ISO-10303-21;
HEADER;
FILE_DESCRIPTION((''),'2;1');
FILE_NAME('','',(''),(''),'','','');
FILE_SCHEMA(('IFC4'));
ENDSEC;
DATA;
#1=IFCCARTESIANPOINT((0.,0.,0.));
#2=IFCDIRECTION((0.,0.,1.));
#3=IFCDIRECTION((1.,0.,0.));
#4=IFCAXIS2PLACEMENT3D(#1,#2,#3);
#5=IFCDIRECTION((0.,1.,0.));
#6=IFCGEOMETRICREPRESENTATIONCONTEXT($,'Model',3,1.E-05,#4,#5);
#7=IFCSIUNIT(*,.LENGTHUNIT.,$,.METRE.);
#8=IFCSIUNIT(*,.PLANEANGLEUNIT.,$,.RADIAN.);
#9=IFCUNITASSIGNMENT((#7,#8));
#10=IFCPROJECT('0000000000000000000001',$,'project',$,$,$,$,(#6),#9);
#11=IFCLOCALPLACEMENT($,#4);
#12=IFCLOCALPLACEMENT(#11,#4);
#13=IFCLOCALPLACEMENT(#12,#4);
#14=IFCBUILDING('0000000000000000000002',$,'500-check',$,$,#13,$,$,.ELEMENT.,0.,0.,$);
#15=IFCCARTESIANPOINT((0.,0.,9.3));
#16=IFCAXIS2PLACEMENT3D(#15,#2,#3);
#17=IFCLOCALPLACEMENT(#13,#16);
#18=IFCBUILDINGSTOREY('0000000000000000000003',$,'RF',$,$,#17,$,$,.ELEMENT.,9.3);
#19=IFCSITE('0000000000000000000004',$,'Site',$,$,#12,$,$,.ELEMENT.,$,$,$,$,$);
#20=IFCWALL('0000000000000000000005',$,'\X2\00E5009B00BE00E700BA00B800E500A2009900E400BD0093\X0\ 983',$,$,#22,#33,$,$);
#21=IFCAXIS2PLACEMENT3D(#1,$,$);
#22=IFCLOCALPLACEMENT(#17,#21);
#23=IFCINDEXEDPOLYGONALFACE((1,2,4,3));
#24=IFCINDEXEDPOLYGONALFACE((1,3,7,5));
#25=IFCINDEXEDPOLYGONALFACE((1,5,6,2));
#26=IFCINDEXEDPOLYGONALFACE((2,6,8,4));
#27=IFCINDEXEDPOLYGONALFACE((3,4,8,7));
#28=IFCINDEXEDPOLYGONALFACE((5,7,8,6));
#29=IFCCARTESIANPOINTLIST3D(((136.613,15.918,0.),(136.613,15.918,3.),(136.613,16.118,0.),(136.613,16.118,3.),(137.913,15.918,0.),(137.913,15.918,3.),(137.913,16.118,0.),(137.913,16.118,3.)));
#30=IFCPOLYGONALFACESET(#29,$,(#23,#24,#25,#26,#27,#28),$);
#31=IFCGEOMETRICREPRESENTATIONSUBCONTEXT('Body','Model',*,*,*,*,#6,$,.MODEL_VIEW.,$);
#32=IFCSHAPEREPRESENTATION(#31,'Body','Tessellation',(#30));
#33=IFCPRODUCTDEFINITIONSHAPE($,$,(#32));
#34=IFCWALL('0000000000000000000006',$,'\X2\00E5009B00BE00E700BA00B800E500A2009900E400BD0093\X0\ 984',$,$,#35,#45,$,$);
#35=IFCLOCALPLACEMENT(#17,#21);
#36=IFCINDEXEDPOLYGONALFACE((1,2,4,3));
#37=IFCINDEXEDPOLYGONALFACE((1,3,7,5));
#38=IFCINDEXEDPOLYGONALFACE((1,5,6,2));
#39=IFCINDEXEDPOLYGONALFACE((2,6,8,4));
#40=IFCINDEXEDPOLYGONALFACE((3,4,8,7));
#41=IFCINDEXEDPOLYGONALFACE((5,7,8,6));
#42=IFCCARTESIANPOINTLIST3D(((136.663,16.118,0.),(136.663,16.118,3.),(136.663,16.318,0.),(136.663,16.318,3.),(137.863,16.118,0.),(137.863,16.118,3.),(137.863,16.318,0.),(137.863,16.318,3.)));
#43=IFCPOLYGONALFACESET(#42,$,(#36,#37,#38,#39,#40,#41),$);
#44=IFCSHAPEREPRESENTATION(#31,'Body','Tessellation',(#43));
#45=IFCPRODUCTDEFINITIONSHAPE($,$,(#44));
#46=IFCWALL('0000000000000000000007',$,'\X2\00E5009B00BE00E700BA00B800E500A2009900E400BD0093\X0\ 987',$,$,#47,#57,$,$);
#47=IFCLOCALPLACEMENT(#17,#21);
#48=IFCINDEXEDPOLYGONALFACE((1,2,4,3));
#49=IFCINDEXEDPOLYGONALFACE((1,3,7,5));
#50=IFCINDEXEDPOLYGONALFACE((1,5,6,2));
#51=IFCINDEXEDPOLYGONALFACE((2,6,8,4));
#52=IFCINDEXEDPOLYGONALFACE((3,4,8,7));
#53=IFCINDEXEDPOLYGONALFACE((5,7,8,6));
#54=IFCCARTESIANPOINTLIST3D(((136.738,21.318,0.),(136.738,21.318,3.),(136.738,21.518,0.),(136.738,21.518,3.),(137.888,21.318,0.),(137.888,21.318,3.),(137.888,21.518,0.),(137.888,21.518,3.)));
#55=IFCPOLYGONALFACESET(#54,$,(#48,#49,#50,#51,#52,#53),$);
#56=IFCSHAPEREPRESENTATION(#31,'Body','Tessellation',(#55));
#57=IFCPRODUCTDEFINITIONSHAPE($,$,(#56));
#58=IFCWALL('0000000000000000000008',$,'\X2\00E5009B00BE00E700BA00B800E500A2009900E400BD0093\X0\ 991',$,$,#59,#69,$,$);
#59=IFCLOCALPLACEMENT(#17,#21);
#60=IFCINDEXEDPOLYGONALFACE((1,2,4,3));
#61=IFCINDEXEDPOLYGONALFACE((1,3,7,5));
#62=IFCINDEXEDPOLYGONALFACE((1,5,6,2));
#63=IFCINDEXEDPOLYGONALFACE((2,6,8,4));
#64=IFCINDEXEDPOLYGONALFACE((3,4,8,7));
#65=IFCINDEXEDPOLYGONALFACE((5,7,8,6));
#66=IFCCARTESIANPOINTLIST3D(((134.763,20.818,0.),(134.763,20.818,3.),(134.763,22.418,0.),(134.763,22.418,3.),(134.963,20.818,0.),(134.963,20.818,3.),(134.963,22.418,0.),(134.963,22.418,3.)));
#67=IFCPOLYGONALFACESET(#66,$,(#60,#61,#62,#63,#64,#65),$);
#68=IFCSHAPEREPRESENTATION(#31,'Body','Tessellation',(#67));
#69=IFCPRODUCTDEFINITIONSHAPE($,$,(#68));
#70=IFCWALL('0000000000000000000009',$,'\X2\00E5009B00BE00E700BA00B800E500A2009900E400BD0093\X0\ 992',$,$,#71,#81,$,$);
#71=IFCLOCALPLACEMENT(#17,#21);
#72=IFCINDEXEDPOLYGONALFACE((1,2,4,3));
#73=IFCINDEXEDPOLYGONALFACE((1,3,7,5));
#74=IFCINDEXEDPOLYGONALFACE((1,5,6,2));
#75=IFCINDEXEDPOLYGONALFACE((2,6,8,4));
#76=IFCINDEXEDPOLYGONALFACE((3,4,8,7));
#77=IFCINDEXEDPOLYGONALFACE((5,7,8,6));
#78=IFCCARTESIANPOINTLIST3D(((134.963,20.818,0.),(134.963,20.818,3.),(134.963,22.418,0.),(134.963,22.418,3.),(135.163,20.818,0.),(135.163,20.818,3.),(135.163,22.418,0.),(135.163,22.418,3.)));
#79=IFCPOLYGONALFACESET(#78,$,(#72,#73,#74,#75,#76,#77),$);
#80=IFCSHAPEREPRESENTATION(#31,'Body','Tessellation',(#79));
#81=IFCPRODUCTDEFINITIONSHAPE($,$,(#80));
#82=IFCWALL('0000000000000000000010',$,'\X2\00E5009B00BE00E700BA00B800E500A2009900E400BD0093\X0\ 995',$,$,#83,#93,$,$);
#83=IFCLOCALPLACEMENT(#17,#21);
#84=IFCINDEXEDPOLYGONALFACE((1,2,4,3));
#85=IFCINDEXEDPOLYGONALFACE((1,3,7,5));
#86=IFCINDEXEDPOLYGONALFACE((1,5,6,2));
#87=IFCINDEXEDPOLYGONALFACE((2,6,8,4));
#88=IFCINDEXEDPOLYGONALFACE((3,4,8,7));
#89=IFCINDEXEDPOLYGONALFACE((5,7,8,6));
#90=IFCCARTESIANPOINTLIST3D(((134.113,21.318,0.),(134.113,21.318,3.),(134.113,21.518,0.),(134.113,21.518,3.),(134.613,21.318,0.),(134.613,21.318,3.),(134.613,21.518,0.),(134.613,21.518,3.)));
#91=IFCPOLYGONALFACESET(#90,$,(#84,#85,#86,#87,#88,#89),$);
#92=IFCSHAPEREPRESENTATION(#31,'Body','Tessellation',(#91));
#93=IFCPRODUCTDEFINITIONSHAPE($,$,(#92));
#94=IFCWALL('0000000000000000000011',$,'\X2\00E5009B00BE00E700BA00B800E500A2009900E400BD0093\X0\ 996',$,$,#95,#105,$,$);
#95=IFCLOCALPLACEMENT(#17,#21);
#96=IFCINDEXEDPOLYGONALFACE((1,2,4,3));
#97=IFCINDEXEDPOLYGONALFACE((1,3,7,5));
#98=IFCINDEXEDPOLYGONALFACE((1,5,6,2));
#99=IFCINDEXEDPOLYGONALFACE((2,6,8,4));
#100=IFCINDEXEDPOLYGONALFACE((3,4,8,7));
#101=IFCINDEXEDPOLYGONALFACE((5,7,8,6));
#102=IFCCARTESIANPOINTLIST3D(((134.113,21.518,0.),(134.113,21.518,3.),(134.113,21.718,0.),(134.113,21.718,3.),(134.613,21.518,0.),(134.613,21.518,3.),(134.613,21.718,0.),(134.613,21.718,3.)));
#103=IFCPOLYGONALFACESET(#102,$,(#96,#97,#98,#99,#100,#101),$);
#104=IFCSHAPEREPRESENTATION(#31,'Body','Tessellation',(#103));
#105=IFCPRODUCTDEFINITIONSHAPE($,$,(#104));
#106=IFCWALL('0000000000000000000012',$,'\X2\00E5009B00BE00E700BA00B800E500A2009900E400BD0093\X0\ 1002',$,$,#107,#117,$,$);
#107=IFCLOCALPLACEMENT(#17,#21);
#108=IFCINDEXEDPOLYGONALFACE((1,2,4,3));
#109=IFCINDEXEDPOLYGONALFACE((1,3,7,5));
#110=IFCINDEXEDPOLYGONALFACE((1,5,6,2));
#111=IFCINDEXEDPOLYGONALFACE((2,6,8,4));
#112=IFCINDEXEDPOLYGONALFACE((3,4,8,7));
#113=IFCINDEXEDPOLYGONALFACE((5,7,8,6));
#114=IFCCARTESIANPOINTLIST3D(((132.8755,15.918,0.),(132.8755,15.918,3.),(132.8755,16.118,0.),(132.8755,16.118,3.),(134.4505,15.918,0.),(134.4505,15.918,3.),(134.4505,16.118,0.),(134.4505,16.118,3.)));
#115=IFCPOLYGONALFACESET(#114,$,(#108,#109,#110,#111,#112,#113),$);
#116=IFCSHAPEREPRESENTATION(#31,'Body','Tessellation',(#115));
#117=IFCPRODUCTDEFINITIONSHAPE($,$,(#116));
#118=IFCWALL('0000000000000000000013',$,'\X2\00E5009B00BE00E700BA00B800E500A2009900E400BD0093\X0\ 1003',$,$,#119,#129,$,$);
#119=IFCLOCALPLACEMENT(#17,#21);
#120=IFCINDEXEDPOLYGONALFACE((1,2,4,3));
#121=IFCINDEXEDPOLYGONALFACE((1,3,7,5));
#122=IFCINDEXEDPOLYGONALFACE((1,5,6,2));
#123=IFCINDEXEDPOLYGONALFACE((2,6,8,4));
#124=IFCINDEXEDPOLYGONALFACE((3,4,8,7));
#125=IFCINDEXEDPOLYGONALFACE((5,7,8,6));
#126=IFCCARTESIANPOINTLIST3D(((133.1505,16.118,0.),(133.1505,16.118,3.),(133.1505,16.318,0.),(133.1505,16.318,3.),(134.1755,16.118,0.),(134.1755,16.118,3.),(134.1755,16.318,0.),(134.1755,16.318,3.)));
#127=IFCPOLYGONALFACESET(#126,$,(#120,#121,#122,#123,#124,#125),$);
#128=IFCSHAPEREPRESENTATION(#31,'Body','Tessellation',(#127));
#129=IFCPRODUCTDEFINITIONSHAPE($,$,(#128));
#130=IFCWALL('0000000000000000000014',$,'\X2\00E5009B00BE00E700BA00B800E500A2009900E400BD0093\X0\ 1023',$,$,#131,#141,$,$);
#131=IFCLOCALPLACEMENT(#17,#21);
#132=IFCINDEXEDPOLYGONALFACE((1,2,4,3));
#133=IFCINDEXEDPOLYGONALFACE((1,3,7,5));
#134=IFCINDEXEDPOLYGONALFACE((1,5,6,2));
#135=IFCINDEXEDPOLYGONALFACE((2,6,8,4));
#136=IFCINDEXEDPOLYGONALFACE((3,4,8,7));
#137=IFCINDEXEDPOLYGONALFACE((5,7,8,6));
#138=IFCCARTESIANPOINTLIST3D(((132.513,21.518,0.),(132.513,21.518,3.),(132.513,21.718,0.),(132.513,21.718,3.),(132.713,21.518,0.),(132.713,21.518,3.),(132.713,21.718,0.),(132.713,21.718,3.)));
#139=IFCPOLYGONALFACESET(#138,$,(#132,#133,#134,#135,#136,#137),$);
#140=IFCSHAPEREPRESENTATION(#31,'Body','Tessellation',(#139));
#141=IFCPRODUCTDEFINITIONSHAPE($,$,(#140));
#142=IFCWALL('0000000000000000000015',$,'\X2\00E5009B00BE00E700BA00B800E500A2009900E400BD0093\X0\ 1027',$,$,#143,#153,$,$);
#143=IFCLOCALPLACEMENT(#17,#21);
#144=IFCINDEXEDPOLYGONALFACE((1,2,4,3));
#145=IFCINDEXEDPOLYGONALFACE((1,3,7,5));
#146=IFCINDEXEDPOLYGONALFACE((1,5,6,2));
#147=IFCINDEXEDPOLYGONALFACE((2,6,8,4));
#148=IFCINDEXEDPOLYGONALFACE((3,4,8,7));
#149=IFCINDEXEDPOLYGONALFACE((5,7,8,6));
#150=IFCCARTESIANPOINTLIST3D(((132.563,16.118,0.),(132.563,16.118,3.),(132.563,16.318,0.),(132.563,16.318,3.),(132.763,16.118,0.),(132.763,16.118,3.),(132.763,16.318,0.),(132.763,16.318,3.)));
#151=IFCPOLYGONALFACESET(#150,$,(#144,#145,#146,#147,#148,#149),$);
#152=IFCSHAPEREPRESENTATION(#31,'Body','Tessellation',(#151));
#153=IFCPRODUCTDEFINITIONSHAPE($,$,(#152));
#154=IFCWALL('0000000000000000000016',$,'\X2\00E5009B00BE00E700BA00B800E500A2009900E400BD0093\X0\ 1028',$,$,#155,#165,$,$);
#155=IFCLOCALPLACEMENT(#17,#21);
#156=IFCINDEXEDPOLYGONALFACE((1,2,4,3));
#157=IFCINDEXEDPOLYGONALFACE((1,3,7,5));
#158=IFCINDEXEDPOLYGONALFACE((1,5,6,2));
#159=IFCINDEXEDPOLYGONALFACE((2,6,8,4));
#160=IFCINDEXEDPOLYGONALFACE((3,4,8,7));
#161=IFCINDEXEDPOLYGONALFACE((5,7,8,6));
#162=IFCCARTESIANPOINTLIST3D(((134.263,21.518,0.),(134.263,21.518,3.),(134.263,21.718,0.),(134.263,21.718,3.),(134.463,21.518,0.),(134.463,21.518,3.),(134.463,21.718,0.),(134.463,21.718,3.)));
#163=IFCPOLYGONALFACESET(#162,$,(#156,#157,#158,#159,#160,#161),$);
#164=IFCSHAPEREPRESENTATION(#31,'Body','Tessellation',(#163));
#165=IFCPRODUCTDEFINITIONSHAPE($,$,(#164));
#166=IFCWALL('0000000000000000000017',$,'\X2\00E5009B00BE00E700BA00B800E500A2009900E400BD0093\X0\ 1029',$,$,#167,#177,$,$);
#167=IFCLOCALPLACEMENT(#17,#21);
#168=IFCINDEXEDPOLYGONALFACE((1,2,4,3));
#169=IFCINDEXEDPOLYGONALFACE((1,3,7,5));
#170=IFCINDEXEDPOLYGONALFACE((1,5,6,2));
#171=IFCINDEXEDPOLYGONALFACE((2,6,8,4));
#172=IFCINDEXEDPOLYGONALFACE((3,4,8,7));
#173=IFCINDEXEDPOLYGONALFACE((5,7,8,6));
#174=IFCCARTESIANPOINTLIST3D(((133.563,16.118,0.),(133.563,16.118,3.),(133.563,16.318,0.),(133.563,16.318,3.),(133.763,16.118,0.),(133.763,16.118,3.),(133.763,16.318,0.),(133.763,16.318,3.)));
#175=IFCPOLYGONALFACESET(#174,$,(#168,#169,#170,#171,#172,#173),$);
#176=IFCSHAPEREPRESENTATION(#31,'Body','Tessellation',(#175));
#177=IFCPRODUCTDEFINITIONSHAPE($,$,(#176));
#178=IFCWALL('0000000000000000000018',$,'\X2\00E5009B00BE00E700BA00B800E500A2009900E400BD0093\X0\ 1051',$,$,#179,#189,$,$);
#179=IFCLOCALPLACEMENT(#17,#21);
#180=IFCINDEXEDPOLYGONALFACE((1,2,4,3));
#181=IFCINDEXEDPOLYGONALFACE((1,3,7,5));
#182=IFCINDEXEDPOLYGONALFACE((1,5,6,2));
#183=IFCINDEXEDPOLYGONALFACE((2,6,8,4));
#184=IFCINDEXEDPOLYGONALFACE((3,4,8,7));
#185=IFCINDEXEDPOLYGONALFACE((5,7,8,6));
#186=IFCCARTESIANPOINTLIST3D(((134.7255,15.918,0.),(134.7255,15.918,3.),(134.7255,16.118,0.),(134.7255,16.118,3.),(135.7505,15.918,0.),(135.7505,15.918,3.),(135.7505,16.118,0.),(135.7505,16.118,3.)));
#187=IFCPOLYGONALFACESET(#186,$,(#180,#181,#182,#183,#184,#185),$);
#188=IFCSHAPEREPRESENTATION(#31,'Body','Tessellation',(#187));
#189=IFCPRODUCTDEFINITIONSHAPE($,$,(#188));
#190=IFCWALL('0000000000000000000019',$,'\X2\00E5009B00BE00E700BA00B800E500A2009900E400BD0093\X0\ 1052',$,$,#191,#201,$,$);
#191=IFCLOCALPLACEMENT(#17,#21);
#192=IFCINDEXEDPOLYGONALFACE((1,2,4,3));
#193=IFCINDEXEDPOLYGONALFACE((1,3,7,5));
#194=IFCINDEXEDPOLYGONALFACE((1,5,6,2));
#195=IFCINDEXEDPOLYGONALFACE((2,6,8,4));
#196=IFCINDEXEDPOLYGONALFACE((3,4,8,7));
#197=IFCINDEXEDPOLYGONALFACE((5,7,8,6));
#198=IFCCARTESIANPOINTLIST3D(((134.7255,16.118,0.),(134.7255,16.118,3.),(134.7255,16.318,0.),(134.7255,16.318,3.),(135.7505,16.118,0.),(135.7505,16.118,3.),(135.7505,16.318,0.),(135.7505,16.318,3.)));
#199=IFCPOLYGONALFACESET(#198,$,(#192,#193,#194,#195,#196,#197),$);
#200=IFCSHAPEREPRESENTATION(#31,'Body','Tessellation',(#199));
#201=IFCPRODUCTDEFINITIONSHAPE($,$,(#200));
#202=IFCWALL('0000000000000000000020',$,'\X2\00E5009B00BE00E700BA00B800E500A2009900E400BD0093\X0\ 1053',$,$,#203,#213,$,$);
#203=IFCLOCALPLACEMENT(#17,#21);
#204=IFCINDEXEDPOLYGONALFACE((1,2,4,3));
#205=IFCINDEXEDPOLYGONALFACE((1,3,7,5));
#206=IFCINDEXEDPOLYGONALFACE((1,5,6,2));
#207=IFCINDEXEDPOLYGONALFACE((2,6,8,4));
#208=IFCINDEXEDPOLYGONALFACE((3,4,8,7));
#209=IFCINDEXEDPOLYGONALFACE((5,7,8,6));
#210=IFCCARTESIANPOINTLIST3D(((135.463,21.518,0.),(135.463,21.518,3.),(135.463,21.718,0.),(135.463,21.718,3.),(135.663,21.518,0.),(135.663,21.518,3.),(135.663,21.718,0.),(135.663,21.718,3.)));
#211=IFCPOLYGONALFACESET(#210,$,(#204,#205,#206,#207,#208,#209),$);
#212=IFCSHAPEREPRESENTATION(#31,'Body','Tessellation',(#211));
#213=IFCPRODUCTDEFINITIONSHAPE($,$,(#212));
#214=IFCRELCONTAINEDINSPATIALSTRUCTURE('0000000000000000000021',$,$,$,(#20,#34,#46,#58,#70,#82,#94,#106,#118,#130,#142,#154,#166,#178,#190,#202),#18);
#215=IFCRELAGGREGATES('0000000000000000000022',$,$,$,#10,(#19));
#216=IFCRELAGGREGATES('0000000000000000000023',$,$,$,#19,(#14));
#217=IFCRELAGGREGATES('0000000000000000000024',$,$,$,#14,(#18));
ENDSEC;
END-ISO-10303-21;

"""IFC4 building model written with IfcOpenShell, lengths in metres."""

from ifc_helpers import new_model, si_unit, direction, frame, frame_2d, origin_with_axes, place, context, subcontext, project, spatial, rectangle, extrude, element, save


model = new_model("IFC4")

# Units and contexts
model_context = context("Model", 3, precision=1e-05, world=origin_with_axes(), true_north=direction((0.0, 1.0, 0.0)))
body_context = subcontext(model_context, "Body", "Model", "MODEL_VIEW")
ifc_project = project(units=[si_unit("LENGTHUNIT", "METRE"), si_unit("PLANEANGLEUNIT", "RADIAN")], contexts=[model_context])

# Site, building, storey
placement = place(None, origin_with_axes())
site_placement = place(placement, origin_with_axes())
site = spatial("IfcSite", under=ifc_project, at=site_placement, Name="Site", CompositionType="ELEMENT")
building_placement = place(site_placement, origin_with_axes())
building = spatial("IfcBuilding", under=site, at=building_placement, Name="500-check", CompositionType="ELEMENT", ElevationOfRefHeight=0.0, ElevationOfTerrain=0.0)
storey_placement = place(building_placement, frame((0.0, 0.0, 9.3), z_axis=(0.0, 0.0, 1.0), x_axis=(1.0, 0.0, 0.0)))
storey = spatial("IfcBuildingStorey", under=building, at=storey_placement, Name="RF", CompositionType="ELEMENT", Elevation=9.3)

# Walls
wall_1_placement = place(storey_placement, frame((137.263, 16.018, 0.0), z_axis=(0.0, 0.0, 1.0), x_axis=(1.0, 0.0, 0.0)))
element("IfcWall", 1, at=wall_1_placement, inside=storey, Name="å\u009b¾çº¸å¢\u0099ä½\u0093 983", context=body_context, shape_type="SweptSolid", body=[
    extrude(rectangle(XDim=1.3, YDim=0.2, at=frame_2d((0.0, 0.0), x_axis=(1.0, 0.0, 0.0))), frame((0.0, 0.0, 0.0), z_axis=(0.0, 0.0, 1.0)), (0.0, 0.0, 1.0), 3.0),
])
wall_2_placement = place(storey_placement, frame((137.263, 16.218, 0.0), z_axis=(0.0, 0.0, 1.0), x_axis=(1.0, 0.0, 0.0)))
element("IfcWall", 2, at=wall_2_placement, inside=storey, Name="å\u009b¾çº¸å¢\u0099ä½\u0093 984", context=body_context, shape_type="SweptSolid", body=[
    extrude(rectangle(XDim=1.2, YDim=0.2, at=frame_2d((0.0, 0.0), x_axis=(1.0, 0.0, 0.0))), frame((0.0, 0.0, 0.0), z_axis=(0.0, 0.0, 1.0)), (0.0, 0.0, 1.0), 3.0),
])
wall_3_placement = place(storey_placement, frame((137.313, 21.418, 0.0), z_axis=(0.0, 0.0, 1.0), x_axis=(1.0, 0.0, 0.0)))
element("IfcWall", 3, at=wall_3_placement, inside=storey, Name="å\u009b¾çº¸å¢\u0099ä½\u0093 987", context=body_context, shape_type="SweptSolid", body=[
    extrude(rectangle(XDim=1.15, YDim=0.2, at=frame_2d((0.0, 0.0), x_axis=(1.0, 0.0, 0.0))), frame((0.0, 0.0, 0.0), z_axis=(0.0, 0.0, 1.0)), (0.0, 0.0, 1.0), 3.0),
])
for number, where, z_axis, x_axis, name in (
    (4, (134.863, 21.618, 0.0), (0.0, 0.0, 1.0), (0.0, 1.0, 0.0), "å\u009b¾çº¸å¢\u0099ä½\u0093 991"),
    (5, (135.063, 21.618, 0.0), (0.0, 0.0, 1.0), (0.0, 1.0, 0.0), "å\u009b¾çº¸å¢\u0099ä½\u0093 992"),
):
    element("IfcWall", number, at=place(storey_placement, frame(where, z_axis=z_axis, x_axis=x_axis)), inside=storey, Name=name, context=body_context, shape_type="SweptSolid", body=[
        extrude(rectangle(XDim=1.6, YDim=0.2, at=frame_2d((0.0, 0.0), x_axis=(1.0, 0.0, 0.0))), frame((0.0, 0.0, 0.0), z_axis=(0.0, 0.0, 1.0)), (0.0, 0.0, 1.0), 3.0),
    ])
for number, where, z_axis, x_axis, name in (
    (6, (134.363, 21.418, 0.0), (0.0, 0.0, 1.0), (1.0, 0.0, 0.0), "å\u009b¾çº¸å¢\u0099ä½\u0093 995"),
    (7, (134.363, 21.618, 0.0), (0.0, 0.0, 1.0), (1.0, 0.0, 0.0), "å\u009b¾çº¸å¢\u0099ä½\u0093 996"),
):
    element("IfcWall", number, at=place(storey_placement, frame(where, z_axis=z_axis, x_axis=x_axis)), inside=storey, Name=name, context=body_context, shape_type="SweptSolid", body=[
        extrude(rectangle(XDim=0.5, YDim=0.2, at=frame_2d((0.0, 0.0), x_axis=(1.0, 0.0, 0.0))), frame((0.0, 0.0, 0.0), z_axis=(0.0, 0.0, 1.0)), (0.0, 0.0, 1.0), 3.0),
    ])
wall_4_placement = place(storey_placement, frame((133.663, 16.018, 0.0), z_axis=(0.0, 0.0, 1.0), x_axis=(1.0, 0.0, 0.0)))
element("IfcWall", 8, at=wall_4_placement, inside=storey, Name="å\u009b¾çº¸å¢\u0099ä½\u0093 1002", context=body_context, shape_type="SweptSolid", body=[
    extrude(rectangle(XDim=1.575, YDim=0.2, at=frame_2d((0.0, 0.0), x_axis=(1.0, 0.0, 0.0))), frame((0.0, 0.0, 0.0), z_axis=(0.0, 0.0, 1.0)), (0.0, 0.0, 1.0), 3.0),
])
wall_5_placement = place(storey_placement, frame((133.663, 16.218, 0.0), z_axis=(0.0, 0.0, 1.0), x_axis=(1.0, 0.0, 0.0)))
element("IfcWall", 9, at=wall_5_placement, inside=storey, Name="å\u009b¾çº¸å¢\u0099ä½\u0093 1003", context=body_context, shape_type="SweptSolid", body=[
    extrude(rectangle(XDim=1.025, YDim=0.2, at=frame_2d((0.0, 0.0), x_axis=(1.0, 0.0, 0.0))), frame((0.0, 0.0, 0.0), z_axis=(0.0, 0.0, 1.0)), (0.0, 0.0, 1.0), 3.0),
])
for number, where, z_axis, x_axis, name in (
    (10, (132.613, 21.618, 0.0), (0.0, 0.0, 1.0), (0.0, -1.0, 0.0), "å\u009b¾çº¸å¢\u0099ä½\u0093 1023"),
    (11, (132.663, 16.218, 0.0), (0.0, 0.0, 1.0), (0.0, -1.0, 0.0), "å\u009b¾çº¸å¢\u0099ä½\u0093 1027"),
    (12, (134.363, 21.618, 0.0), (0.0, 0.0, 1.0), (0.0, -1.0, 0.0), "å\u009b¾çº¸å¢\u0099ä½\u0093 1028"),
    (13, (133.663, 16.218, 0.0), (0.0, 0.0, 1.0), (0.0, -1.0, 0.0), "å\u009b¾çº¸å¢\u0099ä½\u0093 1029"),
):
    element("IfcWall", number, at=place(storey_placement, frame(where, z_axis=z_axis, x_axis=x_axis)), inside=storey, Name=name, context=body_context, shape_type="SweptSolid", body=[
        extrude(rectangle(XDim=0.2, YDim=0.2, at=frame_2d((0.0, 0.0), x_axis=(1.0, 0.0, 0.0))), frame((0.0, 0.0, 0.0), z_axis=(0.0, 0.0, 1.0)), (0.0, 0.0, 1.0), 3.0),
    ])
for number, where, z_axis, x_axis, name in (
    (14, (135.238, 16.018, 0.0), (0.0, 0.0, 1.0), (1.0, 0.0, 0.0), "å\u009b¾çº¸å¢\u0099ä½\u0093 1051"),
    (15, (135.238, 16.218, 0.0), (0.0, 0.0, 1.0), (1.0, 0.0, 0.0), "å\u009b¾çº¸å¢\u0099ä½\u0093 1052"),
):
    element("IfcWall", number, at=place(storey_placement, frame(where, z_axis=z_axis, x_axis=x_axis)), inside=storey, Name=name, context=body_context, shape_type="SweptSolid", body=[
        extrude(rectangle(XDim=1.025, YDim=0.2, at=frame_2d((0.0, 0.0), x_axis=(1.0, 0.0, 0.0))), frame((0.0, 0.0, 0.0), z_axis=(0.0, 0.0, 1.0)), (0.0, 0.0, 1.0), 3.0),
    ])
wall_6_placement = place(storey_placement, frame((135.563, 21.618, 0.0), z_axis=(0.0, 0.0, 1.0), x_axis=(0.0, -1.0, 0.0)))
element("IfcWall", 16, at=wall_6_placement, inside=storey, Name="å\u009b¾çº¸å¢\u0099ä½\u0093 1053", context=body_context, shape_type="SweptSolid", body=[
    extrude(rectangle(XDim=0.2, YDim=0.2, at=frame_2d((0.0, 0.0), x_axis=(1.0, 0.0, 0.0))), frame((0.0, 0.0, 0.0), z_axis=(0.0, 0.0, 1.0)), (0.0, 0.0, 1.0), 3.0),
])

save(model, "model.ifc")
